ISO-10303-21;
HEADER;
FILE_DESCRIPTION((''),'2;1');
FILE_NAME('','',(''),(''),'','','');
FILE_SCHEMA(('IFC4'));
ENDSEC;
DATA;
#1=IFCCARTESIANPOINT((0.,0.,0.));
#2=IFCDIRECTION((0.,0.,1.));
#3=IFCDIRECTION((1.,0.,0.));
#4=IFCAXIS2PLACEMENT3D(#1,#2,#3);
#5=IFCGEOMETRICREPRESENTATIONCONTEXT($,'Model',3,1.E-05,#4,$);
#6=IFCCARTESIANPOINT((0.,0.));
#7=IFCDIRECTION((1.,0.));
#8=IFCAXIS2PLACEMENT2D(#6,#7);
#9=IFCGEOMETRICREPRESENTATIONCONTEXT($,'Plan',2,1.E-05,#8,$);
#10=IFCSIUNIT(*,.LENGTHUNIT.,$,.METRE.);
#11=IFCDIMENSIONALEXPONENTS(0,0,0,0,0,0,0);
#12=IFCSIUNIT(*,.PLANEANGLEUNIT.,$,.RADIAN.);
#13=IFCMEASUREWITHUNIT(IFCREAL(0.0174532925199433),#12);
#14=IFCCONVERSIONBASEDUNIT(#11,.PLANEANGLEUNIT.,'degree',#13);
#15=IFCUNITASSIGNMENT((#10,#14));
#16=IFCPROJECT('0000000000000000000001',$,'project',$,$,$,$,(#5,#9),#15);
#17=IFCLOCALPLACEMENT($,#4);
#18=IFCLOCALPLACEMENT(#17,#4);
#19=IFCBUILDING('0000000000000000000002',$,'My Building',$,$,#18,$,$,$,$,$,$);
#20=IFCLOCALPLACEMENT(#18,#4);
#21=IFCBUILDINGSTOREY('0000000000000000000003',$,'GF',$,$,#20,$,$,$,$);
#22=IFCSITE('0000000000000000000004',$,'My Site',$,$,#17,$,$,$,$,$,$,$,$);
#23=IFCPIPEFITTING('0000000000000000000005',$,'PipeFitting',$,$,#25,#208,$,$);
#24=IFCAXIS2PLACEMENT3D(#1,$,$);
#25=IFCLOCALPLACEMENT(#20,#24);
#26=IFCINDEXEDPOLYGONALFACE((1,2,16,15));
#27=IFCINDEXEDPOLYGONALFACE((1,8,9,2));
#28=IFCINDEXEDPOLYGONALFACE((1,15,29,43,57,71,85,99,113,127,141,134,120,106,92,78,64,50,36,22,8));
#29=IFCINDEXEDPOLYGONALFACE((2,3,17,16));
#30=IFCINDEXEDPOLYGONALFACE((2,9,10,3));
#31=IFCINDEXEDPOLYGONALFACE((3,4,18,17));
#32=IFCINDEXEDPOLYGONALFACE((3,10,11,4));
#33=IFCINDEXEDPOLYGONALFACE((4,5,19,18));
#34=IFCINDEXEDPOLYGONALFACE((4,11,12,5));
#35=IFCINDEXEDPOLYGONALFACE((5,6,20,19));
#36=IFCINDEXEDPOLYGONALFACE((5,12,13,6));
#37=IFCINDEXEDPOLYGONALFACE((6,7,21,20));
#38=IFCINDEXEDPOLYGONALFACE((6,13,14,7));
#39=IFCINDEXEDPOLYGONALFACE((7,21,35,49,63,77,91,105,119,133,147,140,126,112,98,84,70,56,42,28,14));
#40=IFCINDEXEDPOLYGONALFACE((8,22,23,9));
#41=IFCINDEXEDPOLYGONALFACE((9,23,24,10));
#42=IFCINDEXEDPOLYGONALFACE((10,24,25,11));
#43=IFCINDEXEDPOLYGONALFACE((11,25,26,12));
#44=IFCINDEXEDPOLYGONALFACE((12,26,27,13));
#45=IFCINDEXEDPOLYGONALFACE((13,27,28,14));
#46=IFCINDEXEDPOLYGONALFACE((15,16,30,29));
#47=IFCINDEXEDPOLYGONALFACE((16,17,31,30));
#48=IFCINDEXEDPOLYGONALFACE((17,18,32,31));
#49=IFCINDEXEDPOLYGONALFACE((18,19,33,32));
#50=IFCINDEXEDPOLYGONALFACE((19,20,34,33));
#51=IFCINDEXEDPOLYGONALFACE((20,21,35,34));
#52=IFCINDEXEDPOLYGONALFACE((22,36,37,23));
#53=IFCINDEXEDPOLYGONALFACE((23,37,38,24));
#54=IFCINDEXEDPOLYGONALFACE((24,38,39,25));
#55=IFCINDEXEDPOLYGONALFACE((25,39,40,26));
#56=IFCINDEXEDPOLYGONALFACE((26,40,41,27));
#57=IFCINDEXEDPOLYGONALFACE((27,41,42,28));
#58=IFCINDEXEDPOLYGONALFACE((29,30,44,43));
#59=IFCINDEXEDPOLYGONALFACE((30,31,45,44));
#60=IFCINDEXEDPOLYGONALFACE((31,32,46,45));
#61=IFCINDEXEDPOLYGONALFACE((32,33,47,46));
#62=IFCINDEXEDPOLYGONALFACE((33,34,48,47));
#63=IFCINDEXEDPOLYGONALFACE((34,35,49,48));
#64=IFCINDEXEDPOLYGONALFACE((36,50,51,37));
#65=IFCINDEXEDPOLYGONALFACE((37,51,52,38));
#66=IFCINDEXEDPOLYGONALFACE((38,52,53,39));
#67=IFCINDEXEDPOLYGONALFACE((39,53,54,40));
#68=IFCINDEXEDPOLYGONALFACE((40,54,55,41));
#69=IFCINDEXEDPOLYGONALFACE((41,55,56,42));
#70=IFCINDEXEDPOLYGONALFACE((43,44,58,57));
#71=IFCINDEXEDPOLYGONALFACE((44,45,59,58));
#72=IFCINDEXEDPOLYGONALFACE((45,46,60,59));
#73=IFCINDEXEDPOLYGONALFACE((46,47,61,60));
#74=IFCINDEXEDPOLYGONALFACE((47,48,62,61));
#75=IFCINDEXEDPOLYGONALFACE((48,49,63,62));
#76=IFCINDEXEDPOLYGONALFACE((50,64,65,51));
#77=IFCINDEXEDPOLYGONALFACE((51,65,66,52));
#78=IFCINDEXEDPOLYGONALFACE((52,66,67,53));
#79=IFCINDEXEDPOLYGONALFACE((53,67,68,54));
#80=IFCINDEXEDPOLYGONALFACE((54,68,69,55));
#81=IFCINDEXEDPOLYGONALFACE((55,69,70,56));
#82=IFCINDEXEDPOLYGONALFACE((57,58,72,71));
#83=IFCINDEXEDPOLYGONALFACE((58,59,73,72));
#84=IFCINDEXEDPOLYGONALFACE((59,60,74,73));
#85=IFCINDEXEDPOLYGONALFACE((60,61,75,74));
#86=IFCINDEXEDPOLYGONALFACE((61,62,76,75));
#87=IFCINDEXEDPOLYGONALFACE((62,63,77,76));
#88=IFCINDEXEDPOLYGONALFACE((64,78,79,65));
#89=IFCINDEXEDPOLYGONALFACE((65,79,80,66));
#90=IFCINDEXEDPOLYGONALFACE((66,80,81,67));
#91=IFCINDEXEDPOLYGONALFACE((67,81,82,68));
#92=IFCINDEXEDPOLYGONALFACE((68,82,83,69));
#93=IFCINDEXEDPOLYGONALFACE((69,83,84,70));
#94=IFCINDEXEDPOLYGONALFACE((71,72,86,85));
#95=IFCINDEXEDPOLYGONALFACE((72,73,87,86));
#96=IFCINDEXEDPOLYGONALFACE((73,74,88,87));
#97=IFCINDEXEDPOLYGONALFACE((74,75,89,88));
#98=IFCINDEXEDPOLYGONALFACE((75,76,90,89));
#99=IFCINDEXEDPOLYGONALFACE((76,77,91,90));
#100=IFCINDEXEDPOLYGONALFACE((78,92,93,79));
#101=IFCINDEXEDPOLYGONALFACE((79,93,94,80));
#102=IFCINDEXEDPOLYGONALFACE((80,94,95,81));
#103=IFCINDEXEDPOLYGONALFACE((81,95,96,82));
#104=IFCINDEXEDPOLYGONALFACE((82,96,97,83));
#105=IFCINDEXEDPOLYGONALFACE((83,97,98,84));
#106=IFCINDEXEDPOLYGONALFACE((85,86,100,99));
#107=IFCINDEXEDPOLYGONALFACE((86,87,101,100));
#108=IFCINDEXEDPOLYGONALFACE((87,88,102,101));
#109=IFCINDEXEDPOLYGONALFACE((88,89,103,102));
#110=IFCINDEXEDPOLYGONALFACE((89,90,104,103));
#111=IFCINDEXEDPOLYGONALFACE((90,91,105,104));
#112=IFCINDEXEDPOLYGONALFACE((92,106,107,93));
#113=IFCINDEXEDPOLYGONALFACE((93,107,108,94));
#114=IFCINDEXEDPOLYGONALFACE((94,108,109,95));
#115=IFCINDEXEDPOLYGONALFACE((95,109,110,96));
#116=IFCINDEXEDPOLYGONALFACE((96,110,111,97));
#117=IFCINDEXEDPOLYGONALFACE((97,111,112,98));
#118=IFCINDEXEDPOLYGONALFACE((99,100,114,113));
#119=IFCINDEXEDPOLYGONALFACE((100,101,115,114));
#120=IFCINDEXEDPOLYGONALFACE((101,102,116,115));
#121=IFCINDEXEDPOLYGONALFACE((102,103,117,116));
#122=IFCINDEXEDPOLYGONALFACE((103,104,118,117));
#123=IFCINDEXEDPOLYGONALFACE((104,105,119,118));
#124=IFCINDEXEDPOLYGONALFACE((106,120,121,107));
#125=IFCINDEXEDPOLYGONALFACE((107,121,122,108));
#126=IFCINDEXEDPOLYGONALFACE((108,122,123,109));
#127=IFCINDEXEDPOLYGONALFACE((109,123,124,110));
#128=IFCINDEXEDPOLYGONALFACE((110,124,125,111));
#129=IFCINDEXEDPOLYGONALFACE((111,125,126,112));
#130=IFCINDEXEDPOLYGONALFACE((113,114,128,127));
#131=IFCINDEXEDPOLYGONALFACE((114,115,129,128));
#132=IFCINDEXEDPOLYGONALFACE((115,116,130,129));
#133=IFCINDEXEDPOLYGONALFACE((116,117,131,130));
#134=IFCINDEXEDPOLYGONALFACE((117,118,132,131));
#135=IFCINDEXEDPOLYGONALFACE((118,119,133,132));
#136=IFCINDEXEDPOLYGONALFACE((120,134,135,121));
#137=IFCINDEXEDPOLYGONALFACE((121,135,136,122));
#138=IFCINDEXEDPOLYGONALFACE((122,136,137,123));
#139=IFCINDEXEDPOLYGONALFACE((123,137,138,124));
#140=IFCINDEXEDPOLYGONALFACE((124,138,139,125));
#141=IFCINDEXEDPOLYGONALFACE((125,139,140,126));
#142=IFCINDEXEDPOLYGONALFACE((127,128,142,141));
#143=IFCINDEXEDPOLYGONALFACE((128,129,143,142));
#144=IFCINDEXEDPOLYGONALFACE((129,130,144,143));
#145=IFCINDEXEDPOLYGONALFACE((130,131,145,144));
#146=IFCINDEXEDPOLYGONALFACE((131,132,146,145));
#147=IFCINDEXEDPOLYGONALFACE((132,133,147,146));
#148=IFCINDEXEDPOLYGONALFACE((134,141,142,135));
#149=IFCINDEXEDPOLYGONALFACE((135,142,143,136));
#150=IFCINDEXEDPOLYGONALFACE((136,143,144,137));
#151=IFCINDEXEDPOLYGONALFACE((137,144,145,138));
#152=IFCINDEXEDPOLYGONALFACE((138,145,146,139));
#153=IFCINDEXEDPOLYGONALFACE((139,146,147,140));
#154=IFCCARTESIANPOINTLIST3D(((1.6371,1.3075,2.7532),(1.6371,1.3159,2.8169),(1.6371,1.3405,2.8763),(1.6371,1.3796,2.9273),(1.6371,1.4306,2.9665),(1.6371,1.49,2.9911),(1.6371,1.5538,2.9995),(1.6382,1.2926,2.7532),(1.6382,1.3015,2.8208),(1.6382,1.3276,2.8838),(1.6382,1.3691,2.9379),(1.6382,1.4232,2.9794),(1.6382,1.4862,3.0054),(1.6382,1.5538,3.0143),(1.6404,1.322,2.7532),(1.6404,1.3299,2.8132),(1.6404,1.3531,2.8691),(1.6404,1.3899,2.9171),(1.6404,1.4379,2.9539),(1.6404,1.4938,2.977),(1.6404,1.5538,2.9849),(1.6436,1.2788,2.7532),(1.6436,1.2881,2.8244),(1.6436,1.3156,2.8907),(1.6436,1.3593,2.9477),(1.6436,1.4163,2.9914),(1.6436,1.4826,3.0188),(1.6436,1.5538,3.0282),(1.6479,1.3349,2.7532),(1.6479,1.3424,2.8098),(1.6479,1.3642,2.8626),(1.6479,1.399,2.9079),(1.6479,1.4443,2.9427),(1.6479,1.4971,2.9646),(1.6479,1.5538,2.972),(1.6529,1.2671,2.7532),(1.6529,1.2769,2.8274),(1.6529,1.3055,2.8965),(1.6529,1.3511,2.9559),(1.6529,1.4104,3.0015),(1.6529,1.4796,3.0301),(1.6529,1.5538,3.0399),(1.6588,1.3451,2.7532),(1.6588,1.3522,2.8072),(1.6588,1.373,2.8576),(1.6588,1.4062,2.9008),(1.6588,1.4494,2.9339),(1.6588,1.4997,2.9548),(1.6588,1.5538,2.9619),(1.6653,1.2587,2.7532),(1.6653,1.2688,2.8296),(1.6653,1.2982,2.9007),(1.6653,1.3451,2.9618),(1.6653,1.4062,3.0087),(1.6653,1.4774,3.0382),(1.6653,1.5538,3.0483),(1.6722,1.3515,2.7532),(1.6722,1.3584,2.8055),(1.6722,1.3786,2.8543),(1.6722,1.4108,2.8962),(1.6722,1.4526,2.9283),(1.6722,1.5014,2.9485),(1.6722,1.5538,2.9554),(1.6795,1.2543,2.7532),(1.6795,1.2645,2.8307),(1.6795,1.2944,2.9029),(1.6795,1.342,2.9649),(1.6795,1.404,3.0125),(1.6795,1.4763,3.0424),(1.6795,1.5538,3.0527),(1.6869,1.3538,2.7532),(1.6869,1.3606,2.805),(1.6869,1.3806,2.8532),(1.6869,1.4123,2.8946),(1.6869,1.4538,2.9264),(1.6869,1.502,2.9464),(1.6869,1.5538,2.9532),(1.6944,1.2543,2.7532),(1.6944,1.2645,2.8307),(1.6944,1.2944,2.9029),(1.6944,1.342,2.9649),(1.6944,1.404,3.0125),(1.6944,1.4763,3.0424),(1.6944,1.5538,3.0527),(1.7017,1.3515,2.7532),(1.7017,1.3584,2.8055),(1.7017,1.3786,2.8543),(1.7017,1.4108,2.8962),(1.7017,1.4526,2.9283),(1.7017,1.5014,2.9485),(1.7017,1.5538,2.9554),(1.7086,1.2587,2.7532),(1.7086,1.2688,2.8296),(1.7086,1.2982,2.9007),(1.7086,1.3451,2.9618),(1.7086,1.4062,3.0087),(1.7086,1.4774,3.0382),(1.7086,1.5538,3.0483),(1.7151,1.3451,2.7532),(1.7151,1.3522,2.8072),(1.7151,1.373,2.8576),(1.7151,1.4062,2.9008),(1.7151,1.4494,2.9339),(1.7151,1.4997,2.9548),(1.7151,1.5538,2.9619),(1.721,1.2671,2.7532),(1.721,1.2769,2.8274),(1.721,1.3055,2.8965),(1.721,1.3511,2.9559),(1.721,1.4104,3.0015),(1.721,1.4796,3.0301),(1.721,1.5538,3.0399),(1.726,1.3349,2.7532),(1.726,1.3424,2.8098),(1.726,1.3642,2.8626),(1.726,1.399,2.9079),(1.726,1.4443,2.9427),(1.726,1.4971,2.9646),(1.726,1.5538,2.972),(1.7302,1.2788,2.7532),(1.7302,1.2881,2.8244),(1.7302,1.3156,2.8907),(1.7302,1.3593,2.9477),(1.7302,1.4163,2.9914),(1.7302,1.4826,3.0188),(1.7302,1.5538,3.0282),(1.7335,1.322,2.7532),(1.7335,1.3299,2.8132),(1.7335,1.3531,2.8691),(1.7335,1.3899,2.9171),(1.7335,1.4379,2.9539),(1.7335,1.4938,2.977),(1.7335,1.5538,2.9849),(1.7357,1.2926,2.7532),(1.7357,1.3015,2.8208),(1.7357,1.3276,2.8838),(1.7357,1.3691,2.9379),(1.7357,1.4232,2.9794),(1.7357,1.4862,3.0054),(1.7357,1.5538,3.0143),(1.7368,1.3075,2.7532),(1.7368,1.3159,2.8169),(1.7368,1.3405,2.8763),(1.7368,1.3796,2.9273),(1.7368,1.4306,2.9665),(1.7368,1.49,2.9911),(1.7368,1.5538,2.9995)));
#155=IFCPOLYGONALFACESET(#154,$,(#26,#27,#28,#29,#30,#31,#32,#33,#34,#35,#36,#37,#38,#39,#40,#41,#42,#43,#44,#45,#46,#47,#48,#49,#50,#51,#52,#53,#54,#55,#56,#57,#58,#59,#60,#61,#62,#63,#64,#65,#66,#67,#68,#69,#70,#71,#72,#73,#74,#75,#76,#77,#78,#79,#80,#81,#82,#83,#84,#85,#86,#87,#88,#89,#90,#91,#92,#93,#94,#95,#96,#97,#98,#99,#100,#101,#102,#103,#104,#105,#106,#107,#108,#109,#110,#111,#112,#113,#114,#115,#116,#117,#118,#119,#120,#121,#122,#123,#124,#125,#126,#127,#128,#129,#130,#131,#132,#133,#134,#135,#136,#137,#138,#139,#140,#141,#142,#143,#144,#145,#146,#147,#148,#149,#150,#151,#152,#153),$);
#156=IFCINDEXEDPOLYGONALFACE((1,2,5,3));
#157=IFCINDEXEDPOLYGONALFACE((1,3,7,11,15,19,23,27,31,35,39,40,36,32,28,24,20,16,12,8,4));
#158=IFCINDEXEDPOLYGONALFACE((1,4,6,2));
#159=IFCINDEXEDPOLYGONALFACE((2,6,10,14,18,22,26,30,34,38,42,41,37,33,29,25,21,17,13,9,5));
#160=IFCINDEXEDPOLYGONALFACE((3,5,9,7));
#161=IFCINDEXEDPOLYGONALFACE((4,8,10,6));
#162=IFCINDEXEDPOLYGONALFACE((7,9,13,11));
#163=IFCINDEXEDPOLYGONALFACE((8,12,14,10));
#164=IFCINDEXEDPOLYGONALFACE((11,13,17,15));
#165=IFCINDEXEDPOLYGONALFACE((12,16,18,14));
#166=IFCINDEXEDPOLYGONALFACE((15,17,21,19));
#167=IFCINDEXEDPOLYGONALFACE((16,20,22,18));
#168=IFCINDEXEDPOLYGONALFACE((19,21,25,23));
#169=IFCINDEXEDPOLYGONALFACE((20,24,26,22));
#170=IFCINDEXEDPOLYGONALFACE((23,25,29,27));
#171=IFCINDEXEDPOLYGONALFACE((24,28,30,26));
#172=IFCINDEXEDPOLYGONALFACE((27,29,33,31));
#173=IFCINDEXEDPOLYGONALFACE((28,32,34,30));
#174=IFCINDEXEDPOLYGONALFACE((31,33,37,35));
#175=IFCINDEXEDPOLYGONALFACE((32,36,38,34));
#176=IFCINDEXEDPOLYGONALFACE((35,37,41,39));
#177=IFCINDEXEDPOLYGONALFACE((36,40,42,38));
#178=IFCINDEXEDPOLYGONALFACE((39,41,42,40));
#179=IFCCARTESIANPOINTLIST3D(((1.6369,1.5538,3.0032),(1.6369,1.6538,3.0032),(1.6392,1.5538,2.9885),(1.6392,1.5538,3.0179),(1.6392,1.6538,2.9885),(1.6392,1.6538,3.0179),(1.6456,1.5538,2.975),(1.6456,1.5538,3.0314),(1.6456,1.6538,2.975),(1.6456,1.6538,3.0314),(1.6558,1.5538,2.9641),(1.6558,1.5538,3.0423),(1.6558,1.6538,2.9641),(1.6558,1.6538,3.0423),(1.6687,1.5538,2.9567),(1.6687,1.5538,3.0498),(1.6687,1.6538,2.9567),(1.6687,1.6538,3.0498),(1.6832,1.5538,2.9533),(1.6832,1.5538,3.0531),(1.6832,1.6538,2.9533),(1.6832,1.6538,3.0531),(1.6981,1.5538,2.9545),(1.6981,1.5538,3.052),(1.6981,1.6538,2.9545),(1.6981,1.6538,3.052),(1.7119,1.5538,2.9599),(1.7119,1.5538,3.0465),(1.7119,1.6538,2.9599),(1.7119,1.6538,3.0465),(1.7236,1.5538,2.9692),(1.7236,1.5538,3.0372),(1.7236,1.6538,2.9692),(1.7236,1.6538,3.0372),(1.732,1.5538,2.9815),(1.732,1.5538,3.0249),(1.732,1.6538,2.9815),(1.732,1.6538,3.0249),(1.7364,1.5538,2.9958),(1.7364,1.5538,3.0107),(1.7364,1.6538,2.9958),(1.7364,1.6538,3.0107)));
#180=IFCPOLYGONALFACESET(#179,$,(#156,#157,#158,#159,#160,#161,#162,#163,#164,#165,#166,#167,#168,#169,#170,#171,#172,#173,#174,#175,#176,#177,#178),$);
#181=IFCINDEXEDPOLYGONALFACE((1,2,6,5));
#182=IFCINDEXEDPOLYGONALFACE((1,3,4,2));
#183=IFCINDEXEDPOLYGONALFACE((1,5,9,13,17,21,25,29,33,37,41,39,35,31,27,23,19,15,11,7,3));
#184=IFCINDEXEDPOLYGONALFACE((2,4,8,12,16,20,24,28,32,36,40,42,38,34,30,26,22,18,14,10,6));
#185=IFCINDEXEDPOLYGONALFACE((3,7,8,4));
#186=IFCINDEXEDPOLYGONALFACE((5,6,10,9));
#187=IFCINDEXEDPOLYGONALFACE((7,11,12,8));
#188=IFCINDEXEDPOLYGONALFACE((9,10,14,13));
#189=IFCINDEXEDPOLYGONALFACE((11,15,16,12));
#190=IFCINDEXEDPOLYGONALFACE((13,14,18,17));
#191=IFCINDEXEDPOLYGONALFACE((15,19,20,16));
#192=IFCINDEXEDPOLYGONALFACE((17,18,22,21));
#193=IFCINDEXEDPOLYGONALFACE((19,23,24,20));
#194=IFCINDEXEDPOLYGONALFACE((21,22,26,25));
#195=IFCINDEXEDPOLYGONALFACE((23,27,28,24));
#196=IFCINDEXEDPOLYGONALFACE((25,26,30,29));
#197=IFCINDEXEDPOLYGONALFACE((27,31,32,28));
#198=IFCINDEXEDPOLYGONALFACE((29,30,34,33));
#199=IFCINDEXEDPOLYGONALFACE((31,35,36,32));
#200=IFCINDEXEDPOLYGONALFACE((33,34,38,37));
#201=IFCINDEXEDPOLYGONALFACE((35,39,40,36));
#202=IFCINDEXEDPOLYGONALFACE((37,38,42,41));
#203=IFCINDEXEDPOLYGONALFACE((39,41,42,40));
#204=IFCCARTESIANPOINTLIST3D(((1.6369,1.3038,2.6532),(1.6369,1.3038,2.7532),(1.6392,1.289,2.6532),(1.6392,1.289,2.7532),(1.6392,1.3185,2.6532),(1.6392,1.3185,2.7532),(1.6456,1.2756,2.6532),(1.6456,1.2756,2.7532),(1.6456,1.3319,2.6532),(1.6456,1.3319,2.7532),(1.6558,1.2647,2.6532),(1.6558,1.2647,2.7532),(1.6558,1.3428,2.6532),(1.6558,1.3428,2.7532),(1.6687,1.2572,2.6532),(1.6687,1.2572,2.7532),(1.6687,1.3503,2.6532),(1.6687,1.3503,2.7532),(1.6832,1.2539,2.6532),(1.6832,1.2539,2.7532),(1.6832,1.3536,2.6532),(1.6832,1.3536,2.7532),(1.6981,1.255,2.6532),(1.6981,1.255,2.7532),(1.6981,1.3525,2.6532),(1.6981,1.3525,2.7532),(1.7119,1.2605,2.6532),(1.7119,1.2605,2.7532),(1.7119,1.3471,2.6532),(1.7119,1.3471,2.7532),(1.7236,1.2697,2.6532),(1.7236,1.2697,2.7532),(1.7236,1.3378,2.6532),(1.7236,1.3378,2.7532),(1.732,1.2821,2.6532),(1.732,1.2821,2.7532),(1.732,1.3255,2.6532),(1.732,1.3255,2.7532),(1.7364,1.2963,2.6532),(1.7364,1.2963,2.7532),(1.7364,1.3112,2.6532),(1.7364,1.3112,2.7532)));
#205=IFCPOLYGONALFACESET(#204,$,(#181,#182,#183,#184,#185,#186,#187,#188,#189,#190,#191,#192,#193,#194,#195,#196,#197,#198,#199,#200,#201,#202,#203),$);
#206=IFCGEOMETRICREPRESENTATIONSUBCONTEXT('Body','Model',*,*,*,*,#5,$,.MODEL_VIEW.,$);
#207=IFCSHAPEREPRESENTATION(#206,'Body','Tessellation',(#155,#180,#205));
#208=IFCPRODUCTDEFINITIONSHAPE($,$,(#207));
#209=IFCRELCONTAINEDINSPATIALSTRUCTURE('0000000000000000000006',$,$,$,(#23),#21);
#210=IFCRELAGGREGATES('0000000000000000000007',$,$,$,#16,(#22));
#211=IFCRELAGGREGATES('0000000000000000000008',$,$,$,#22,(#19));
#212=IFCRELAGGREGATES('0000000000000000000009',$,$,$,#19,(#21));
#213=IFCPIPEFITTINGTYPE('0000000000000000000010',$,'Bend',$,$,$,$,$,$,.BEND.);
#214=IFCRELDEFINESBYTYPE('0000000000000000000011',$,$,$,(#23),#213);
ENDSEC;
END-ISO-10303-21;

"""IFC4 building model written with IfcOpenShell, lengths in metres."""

from ifc_helpers import new_model, entity, si_unit, converted_unit, frame, origin_with_axes, origin_2d_with_axis, place, context, subcontext, project, spatial, line, indexed_curve, circle, outline, extrude, source, transform, mapped, type_object, type_shapes, element, save


model = new_model("IFC4")

# Units and contexts
model_context = context("Model", 3, precision=1e-05, world=origin_with_axes())
plan_context = context("Plan", 2, precision=1e-05, world=origin_2d_with_axis())
body_context_1 = subcontext(model_context, "Body", "Model", "MODEL_VIEW")
ifc_project = project(units=[si_unit("LENGTHUNIT", "METRE"), converted_unit("PLANEANGLEUNIT", "degree", entity("IfcReal", 0.0174532925199433), si_unit("PLANEANGLEUNIT", "RADIAN"), dimensions=[0, 0, 0, 0, 0, 0, 0])], contexts=[model_context, plan_context])

# Site, building, storey
site_placement = place(None, origin_with_axes())
site = spatial("IfcSite", under=ifc_project, at=site_placement, Name="My Site")
building_placement = place(site_placement, origin_with_axes())
building = spatial("IfcBuilding", under=site, at=building_placement, Name="My Building")
storey_placement = place(building_placement, origin_with_axes())
storey = spatial("IfcBuildingStorey", under=building, at=storey_placement, Name="GF")

# Shared definitions
pipe_fitting_type = type_object("IfcPipeFittingType", Name="Bend", PredefinedType="BEND")
shared_shape_1 = source(origin_with_axes(), body_context_1, "Body", "SolidModel", [
    entity("IfcSweptDiskSolid", entity("IfcIndexedPolyCurve", entity("IfcCartesianPointList3D", [[0.0, 0.0, -0.1], [0.0, -0.0732, -0.2768], [0.0, -0.25, -0.35]]), [entity("IfcArcIndex", [1, 2, 3])]), 0.05),
    extrude(circle(Radius=0.05), origin_with_axes(), (0.0, 0.0, -1.0), 0.1),
    extrude(circle(Radius=0.05), frame((0.0, -0.25, -0.35), z_axis=(0.0, -1.0, 0.0), x_axis=(1.0, 0.0, 0.0)), (0.0, 0.0, 1.0), 0.1),
])
type_shapes(pipe_fitting_type, [shared_shape_1])

# Pipe fitting, opening
pipe_fitting_1_placement = place(storey_placement, frame((1.6869, 1.6538, 3.0032), z_axis=(0.0, 1.0, 0.0), x_axis=(-1.0, 0.0, 0.0)))
pipe_fitting_1 = element("IfcPipeFitting", 1, at=pipe_fitting_1_placement, inside=storey, type_object=pipe_fitting_type, Name="PipeFitting", context=body_context_1, shape_type="MappedRepresentation", body=[
    mapped(shared_shape_1, transform((0.0, 0.0, 0.0), x_axis=(1.0, 0.0, 0.0), y_axis=(0.0, 1.0, 0.0), z_axis=(0.0, 0.0, 1.0), scale=1.0)),
])
opening_1_placement = place(pipe_fitting_1_placement, frame((1.6869, -3.0032, -1.6538), z_axis=(0.0, 1.0, 0.0), x_axis=(-1.0, 0.0, 0.0)))
element("IfcOpeningElement", 2, at=opening_1_placement, cuts=pipe_fitting_1, PredefinedType="OPENING", context=body_context_1, shape_type="SweptSolid", body=[
    extrude(outline(indexed_curve([(0.0, 0.0), (0.5, 0.0), (0.5, 0.5), (0.0, 0.5)], segments=[line(1, 2, 3, 4, 1)])), origin_with_axes(), (0.0, 0.0, 1.0), 0.5),
])

save(model, "model.ifc")
